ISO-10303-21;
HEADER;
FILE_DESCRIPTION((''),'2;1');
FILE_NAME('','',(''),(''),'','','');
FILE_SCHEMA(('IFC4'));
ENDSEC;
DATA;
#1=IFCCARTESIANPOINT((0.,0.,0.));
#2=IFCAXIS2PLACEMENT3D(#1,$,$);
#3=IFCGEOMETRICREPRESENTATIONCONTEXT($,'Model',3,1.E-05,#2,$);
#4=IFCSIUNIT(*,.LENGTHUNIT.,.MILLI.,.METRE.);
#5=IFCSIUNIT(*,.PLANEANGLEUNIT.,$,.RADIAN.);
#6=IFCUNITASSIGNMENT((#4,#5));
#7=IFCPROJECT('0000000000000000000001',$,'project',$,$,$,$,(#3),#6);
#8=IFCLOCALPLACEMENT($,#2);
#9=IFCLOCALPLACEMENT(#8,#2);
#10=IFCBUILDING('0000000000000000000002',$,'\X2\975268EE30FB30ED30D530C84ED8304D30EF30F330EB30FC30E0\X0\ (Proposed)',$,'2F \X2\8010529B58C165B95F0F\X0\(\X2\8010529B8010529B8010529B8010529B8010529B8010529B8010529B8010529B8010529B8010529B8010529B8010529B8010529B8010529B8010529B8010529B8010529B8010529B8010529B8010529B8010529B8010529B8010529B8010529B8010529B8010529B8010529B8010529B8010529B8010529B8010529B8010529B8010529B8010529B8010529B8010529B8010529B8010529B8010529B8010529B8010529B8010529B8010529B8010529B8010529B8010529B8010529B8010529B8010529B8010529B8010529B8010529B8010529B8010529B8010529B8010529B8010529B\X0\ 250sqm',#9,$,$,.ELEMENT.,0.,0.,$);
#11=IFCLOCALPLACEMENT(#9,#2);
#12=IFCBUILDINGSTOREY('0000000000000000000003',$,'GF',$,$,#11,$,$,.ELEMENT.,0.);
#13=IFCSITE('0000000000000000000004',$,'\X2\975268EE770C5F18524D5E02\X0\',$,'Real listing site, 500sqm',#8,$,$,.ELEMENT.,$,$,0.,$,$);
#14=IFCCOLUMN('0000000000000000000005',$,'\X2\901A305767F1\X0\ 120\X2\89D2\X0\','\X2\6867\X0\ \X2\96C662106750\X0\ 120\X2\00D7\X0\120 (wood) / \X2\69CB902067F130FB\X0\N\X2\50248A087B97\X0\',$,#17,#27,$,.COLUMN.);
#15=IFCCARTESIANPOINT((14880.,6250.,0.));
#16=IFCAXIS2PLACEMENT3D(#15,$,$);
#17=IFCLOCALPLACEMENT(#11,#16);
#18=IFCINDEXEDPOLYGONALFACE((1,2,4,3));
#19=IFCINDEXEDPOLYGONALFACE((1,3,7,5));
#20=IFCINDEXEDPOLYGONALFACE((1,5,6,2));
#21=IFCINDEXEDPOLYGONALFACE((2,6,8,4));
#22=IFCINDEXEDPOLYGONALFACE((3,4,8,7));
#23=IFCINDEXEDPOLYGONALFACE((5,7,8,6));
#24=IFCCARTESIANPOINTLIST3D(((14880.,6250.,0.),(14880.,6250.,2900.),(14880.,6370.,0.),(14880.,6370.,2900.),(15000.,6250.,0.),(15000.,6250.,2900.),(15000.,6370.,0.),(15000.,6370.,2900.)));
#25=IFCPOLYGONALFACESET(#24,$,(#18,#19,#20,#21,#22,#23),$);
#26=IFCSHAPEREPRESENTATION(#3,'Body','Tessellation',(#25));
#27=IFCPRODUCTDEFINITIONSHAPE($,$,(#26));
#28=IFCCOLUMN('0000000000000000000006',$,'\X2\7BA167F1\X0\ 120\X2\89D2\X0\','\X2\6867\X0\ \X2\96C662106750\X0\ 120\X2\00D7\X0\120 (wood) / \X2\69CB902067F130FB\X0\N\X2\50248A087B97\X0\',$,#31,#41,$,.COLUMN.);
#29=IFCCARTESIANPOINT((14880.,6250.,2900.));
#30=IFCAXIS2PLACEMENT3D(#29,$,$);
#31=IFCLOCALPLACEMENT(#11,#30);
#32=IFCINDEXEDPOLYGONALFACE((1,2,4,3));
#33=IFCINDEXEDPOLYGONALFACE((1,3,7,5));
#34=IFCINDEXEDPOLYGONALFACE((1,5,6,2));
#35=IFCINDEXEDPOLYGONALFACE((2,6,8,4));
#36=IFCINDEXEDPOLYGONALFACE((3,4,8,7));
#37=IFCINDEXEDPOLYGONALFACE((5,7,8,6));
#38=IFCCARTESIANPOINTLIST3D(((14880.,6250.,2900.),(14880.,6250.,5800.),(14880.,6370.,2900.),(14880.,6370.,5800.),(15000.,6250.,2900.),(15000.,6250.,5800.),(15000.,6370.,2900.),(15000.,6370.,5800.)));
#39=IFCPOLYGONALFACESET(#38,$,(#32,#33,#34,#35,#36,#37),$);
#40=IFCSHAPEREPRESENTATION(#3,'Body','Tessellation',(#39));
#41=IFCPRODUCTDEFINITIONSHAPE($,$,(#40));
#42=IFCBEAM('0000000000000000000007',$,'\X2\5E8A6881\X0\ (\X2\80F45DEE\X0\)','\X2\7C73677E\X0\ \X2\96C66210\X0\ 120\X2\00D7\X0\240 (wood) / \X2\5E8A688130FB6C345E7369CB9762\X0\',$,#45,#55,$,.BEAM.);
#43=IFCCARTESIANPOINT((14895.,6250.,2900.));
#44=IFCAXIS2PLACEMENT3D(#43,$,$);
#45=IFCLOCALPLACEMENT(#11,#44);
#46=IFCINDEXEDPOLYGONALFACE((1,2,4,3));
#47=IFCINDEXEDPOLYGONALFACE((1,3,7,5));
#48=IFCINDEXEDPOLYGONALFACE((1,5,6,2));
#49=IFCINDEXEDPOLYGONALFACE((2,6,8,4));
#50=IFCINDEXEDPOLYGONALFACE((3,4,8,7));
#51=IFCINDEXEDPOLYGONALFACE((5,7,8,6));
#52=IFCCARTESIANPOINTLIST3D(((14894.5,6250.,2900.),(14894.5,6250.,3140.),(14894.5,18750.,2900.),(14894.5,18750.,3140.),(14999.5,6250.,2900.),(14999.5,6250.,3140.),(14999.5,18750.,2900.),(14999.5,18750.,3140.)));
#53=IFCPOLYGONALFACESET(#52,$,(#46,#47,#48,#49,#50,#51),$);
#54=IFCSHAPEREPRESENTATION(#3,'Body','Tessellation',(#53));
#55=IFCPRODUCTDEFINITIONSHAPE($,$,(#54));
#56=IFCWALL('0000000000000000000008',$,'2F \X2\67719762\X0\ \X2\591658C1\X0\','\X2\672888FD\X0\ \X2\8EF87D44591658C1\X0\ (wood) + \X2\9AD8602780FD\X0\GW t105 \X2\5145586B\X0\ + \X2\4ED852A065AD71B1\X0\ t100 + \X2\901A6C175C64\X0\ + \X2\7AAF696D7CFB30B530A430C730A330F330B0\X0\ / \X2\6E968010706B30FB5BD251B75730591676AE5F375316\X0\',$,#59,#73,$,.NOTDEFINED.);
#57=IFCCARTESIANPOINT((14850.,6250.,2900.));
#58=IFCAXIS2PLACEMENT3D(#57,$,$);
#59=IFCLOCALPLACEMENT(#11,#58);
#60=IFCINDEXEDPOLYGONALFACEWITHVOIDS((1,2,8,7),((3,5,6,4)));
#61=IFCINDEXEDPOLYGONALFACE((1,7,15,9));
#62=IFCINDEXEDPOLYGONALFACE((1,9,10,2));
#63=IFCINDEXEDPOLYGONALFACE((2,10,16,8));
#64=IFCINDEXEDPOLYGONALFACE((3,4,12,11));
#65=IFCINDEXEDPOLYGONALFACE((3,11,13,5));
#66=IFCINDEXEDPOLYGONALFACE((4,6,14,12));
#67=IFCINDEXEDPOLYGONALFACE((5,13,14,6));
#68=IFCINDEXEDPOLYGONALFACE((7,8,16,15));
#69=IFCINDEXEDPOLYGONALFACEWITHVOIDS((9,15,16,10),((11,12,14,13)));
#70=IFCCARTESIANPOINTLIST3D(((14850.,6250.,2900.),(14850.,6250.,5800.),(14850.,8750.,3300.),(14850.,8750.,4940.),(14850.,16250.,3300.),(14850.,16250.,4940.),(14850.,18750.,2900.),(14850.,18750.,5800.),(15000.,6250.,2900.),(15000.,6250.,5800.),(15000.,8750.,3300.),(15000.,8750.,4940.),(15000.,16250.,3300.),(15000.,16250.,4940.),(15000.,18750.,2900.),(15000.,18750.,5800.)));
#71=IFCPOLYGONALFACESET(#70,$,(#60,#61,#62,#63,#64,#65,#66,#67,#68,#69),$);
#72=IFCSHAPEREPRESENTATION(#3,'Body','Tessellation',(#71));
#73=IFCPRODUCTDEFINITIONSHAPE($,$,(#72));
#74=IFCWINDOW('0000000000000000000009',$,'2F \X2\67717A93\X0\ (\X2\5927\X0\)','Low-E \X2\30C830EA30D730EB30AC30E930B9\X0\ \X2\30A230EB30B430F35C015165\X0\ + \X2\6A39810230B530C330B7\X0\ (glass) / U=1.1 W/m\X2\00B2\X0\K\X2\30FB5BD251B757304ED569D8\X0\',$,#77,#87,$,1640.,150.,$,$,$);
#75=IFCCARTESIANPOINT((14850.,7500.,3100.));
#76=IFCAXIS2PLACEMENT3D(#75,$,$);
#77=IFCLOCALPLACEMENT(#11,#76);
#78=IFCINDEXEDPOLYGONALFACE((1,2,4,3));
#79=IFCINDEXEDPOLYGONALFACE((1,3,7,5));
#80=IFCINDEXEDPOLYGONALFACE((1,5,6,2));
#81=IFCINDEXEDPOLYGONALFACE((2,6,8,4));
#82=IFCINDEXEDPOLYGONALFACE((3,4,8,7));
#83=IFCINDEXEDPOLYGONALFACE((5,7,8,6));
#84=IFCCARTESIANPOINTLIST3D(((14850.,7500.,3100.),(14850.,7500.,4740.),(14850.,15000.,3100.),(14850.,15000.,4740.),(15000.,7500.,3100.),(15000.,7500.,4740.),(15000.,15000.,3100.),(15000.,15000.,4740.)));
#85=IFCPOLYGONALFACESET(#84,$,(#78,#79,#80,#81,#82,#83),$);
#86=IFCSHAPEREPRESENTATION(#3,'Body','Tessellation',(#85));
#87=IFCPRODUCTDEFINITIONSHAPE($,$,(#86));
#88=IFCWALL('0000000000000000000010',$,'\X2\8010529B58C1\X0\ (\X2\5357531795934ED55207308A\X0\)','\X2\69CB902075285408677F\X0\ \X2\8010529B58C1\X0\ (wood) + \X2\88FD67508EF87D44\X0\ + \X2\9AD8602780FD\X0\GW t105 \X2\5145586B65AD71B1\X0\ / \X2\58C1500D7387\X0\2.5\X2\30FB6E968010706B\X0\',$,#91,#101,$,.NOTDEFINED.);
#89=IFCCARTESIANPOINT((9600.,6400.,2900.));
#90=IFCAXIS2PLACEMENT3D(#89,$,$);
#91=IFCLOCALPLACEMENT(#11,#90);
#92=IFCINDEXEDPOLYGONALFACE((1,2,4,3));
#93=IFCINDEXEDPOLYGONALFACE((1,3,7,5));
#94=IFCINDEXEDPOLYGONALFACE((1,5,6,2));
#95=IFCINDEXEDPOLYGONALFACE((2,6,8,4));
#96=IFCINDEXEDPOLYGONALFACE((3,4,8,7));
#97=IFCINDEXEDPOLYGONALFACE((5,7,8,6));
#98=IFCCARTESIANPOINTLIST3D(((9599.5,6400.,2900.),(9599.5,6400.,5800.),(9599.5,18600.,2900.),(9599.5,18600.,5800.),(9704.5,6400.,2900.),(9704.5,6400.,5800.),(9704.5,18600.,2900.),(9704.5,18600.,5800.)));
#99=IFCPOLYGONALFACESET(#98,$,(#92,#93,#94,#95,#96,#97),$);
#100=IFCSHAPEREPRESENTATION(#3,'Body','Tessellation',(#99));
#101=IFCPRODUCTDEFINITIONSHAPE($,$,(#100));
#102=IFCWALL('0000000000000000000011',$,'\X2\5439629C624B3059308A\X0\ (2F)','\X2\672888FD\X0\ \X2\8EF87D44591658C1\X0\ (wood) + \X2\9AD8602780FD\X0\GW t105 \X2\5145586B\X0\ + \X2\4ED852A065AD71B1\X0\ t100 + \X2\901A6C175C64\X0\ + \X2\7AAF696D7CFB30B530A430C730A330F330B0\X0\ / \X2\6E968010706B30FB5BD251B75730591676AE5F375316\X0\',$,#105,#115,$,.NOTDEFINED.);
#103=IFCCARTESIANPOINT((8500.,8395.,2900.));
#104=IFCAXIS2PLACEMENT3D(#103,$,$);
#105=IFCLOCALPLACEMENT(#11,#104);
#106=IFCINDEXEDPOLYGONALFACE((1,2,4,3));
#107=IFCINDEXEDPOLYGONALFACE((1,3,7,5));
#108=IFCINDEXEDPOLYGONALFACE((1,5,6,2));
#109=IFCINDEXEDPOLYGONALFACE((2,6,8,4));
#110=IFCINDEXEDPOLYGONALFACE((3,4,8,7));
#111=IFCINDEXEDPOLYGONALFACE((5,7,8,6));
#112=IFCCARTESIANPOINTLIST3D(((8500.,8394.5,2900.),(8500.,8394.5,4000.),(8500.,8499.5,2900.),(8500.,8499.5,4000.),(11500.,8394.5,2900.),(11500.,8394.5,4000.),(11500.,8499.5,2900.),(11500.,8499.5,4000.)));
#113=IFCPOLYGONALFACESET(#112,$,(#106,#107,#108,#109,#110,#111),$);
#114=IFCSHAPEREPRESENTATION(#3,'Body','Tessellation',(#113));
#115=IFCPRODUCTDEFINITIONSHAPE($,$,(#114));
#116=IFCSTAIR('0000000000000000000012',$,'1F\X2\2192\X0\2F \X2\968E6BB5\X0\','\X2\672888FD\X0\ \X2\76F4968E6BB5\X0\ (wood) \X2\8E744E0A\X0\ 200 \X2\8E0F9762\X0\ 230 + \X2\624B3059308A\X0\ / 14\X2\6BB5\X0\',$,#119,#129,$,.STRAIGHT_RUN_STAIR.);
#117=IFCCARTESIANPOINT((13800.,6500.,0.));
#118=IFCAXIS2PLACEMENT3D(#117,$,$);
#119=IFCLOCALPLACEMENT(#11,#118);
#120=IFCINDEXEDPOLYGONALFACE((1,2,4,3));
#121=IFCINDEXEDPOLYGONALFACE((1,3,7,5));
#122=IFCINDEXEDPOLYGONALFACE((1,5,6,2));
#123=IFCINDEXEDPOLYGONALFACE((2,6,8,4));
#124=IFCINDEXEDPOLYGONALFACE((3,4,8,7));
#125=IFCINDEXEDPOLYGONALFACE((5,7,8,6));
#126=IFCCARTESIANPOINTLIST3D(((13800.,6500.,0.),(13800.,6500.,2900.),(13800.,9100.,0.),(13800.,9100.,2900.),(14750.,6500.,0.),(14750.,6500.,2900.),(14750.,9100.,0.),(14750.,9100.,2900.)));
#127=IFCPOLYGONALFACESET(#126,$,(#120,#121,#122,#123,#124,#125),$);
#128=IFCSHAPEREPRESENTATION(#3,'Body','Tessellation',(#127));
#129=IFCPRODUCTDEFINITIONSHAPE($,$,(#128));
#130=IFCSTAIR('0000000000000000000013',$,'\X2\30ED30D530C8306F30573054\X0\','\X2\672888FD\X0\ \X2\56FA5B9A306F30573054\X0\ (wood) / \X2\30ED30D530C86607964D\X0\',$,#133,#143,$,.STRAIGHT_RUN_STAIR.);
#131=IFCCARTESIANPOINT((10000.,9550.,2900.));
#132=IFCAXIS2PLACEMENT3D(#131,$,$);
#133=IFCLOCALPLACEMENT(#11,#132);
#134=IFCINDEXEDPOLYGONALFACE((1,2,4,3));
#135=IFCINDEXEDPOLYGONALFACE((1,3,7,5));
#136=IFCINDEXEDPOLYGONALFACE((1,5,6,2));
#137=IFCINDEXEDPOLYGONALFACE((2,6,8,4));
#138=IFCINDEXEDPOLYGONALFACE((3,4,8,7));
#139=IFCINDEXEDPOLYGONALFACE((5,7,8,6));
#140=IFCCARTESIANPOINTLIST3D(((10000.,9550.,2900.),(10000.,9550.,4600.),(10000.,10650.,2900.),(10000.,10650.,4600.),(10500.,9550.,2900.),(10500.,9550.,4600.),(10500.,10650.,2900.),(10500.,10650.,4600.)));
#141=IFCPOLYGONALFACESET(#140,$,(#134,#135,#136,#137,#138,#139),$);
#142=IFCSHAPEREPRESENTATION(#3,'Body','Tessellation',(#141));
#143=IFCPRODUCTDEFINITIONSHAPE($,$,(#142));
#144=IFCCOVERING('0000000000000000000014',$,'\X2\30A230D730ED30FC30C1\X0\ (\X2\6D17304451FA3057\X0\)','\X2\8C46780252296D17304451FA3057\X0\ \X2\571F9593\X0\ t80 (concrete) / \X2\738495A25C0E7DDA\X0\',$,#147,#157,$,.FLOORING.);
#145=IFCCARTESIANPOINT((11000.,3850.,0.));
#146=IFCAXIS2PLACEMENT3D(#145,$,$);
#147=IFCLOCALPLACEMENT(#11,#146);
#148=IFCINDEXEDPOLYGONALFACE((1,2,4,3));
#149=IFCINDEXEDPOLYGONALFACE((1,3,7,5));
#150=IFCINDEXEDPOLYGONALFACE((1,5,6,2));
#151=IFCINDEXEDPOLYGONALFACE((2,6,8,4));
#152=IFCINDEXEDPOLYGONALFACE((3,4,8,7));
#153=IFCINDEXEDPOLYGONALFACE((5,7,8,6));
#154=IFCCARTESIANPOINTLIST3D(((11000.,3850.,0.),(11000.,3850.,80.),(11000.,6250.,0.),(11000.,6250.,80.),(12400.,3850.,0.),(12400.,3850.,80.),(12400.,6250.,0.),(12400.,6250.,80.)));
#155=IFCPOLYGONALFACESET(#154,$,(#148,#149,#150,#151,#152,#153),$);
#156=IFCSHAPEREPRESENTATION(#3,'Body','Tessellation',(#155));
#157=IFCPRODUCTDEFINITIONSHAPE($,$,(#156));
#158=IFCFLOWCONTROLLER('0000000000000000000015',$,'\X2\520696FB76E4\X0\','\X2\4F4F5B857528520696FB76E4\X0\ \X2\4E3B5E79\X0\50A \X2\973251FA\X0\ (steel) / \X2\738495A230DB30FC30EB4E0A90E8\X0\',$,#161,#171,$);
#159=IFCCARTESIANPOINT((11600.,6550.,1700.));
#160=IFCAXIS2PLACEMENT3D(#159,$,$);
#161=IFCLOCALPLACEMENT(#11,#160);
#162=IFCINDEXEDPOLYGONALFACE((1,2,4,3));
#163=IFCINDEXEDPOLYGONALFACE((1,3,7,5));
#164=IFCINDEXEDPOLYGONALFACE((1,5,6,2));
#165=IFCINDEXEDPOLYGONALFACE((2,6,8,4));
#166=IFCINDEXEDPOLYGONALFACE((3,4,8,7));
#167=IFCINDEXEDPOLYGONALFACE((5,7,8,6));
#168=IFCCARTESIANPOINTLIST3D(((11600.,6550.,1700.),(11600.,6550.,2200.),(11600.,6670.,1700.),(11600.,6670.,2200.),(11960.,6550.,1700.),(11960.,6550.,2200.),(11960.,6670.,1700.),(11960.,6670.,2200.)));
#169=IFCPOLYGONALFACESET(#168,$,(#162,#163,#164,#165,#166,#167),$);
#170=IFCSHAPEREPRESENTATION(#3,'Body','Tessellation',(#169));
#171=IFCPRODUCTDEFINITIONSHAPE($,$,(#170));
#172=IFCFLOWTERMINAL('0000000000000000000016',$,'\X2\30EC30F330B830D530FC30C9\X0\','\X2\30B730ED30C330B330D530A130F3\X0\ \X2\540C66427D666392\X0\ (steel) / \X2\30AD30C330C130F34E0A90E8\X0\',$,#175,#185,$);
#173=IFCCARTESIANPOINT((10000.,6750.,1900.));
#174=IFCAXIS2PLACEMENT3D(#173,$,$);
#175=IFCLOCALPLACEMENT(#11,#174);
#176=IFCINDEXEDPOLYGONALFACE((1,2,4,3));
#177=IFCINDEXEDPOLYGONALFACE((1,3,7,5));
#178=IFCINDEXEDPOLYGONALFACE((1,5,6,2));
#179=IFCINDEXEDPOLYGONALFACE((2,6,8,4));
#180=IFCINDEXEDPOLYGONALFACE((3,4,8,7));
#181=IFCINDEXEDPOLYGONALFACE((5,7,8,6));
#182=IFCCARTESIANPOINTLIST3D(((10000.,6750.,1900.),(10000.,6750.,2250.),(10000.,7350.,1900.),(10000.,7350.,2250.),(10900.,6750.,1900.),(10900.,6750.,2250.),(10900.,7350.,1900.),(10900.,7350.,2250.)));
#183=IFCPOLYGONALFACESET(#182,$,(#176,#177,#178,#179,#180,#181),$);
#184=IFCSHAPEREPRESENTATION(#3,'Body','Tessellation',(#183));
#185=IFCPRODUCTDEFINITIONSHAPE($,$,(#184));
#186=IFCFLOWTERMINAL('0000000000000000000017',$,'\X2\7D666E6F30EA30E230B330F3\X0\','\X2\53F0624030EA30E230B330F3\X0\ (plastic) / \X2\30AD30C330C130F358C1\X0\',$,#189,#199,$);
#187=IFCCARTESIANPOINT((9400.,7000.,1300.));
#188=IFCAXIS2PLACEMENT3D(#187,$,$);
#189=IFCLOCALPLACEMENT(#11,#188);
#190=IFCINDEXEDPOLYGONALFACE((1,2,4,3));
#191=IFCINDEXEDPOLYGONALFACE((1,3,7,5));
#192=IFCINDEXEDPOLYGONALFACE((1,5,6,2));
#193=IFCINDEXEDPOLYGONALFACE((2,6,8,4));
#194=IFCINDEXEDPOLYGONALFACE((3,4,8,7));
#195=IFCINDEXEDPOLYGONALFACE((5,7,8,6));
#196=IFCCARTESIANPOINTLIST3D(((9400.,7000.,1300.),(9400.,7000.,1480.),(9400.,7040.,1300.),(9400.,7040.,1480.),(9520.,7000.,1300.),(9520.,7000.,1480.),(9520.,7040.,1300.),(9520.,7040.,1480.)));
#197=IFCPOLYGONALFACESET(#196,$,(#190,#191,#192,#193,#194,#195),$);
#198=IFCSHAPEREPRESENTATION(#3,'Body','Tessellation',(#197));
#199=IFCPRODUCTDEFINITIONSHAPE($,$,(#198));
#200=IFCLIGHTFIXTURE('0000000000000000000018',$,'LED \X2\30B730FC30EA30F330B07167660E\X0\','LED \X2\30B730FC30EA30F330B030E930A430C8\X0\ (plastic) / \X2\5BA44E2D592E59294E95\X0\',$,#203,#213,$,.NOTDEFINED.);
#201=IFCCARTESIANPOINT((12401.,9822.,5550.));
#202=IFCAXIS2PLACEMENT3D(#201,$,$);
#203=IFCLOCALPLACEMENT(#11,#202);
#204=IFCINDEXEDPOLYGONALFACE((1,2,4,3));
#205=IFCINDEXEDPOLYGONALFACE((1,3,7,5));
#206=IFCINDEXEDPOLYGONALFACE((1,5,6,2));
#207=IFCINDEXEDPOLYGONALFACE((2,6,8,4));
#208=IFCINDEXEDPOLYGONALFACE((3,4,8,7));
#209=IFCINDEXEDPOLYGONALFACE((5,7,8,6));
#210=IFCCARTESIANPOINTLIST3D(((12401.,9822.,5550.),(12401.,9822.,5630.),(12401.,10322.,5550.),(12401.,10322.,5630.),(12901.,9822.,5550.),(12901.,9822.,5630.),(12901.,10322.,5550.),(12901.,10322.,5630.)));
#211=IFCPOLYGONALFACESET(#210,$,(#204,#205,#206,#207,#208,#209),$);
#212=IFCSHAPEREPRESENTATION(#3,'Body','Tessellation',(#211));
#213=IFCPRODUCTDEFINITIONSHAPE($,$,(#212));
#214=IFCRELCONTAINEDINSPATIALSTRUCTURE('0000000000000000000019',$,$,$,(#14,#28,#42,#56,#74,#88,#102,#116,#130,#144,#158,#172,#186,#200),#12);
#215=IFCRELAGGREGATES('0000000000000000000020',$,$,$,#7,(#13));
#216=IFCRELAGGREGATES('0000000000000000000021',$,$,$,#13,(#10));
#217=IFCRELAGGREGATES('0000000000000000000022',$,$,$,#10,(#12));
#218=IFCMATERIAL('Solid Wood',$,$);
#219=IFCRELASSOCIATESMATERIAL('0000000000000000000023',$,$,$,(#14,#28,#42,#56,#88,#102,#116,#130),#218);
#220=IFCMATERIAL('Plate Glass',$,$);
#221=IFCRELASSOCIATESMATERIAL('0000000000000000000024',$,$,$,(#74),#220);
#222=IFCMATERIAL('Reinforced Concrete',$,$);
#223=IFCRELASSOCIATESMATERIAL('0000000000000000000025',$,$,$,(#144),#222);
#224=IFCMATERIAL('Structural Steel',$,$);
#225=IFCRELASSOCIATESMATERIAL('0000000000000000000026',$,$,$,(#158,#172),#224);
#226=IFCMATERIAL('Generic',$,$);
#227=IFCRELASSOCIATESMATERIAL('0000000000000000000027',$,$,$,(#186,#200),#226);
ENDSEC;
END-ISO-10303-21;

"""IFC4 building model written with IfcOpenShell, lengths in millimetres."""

from ifc_helpers import new_model, si_unit, frame, frame_2d, origin, place, context, project, spatial, rectangle, extrude, material, element, fill, save


model = new_model("IFC4")

# Units and contexts
model_context = context("Model", 3, precision=1e-05, world=origin())
ifc_project = project(units=[si_unit("LENGTHUNIT", "METRE", prefix="MILLI"), si_unit("PLANEANGLEUNIT", "RADIAN")], contexts=[model_context])

# Site, building, storey
site_placement = place(None, origin())
site = spatial("IfcSite", under=ifc_project, at=site_placement, Name="青森県弘前市", ObjectType="Real listing site, 500sqm", CompositionType="ELEMENT", RefElevation=0.0)
building_placement = place(site_placement, origin())
building = spatial("IfcBuilding", under=site, at=building_placement, Name="青森・ロフト付きワンルーム (Proposed)", ObjectType="2F 耐力壁方式(耐力耐力耐力耐力耐力耐力耐力耐力耐力耐力耐力耐力耐力耐力耐力耐力耐力耐力耐力耐力耐力耐力耐力耐力耐力耐力耐力耐力耐力耐力耐力耐力耐力耐力耐力耐力耐力耐力耐力耐力耐力耐力耐力耐力耐力耐力耐力耐力耐力耐力耐力耐力耐力耐力耐力耐力耐力 250sqm", CompositionType="ELEMENT", ElevationOfRefHeight=0.0, ElevationOfTerrain=0.0)
storey_placement = place(building_placement, origin())
storey = spatial("IfcBuildingStorey", under=building, at=storey_placement, Name="GF", CompositionType="ELEMENT", Elevation=0.0)

# Columns
ifc_material_1 = material(Name="Solid Wood")
column_1_placement = place(storey_placement, frame((14880.0, 6250.0, 0.0)))
element("IfcColumn", 1, at=column_1_placement, inside=storey, material=ifc_material_1, Name="通し柱 120角", Description="桧 集成材 120×120 (wood) / 構造柱・N値計算", PredefinedType="COLUMN", context=model_context, shape_type="SweptSolid", body=[
    extrude(rectangle(XDim=120.0, YDim=120.0, at=frame_2d((60.0, 60.0))), frame((14880.0, 6250.0, 0.0)), (0.0, 0.0, 1.0), 2900.0),
])
column_2_placement = place(storey_placement, frame((14880.0, 6250.0, 2900.0)))
element("IfcColumn", 2, at=column_2_placement, inside=storey, material=ifc_material_1, Name="管柱 120角", Description="桧 集成材 120×120 (wood) / 構造柱・N値計算", PredefinedType="COLUMN", context=model_context, shape_type="SweptSolid", body=[
    extrude(rectangle(XDim=120.0, YDim=120.0, at=frame_2d((60.0, 60.0))), frame((14880.0, 6250.0, 2900.0)), (0.0, 0.0, 1.0), 2900.0),
])

# Beam
beam_1_placement = place(storey_placement, frame((14895.0, 6250.0, 2900.0)))
element("IfcBeam", 3, at=beam_1_placement, inside=storey, material=ifc_material_1, Name="床梁 (胴差)", Description="米松 集成 120×240 (wood) / 床梁・水平構面", PredefinedType="BEAM", context=model_context, shape_type="SweptSolid", body=[
    extrude(rectangle(XDim=105.0, YDim=12500.0, at=frame_2d((52.0, 6250.0))), frame((14895.0, 6250.0, 2900.0)), (0.0, 0.0, 1.0), 240.0),
])

# Shared definitions
ifc_material_2 = material(Name="Plate Glass")

# Wall, opening, window
wall_1_placement = place(storey_placement, frame((14850.0, 6250.0, 2900.0)))
wall_1 = element("IfcWall", 4, at=wall_1_placement, inside=storey, material=ifc_material_1, Name="2F 東面 外壁", Description="木製 軸組外壁 (wood) + 高性能GW t105 充填 + 付加断熱 t100 + 通気層 + 窯業系サイディング / 準耐火・寒冷地外皮強化", PredefinedType="NOTDEFINED", context=model_context, shape_type="SweptSolid", body=[
    extrude(rectangle(XDim=150.0, YDim=12500.0, at=frame_2d((75.0, 6250.0))), frame((14850.0, 6250.0, 2900.0)), (0.0, 0.0, 1.0), 2900.0),
])
opening_1_placement = place(storey_placement, frame((14850.0, 7500.0, 3100.0)))
opening_1 = element("IfcOpeningElement", 5, at=opening_1_placement, cuts=wall_1, PredefinedType="NOTDEFINED", context=model_context, shape_type="SweptSolid", body=[
    extrude(rectangle(XDim=150.0, YDim=7500.0, at=frame_2d((75.0, 3750.0))), frame((14850.0, 7500.0, 3100.0)), (0.0, 0.0, 1.0), 1640.0),
])
window_1_placement = place(storey_placement, frame((14850.0, 7500.0, 3100.0)))
window_1 = element("IfcWindow", 6, at=window_1_placement, inside=storey, material=ifc_material_2, Name="2F 東窓 (大)", Description="Low-E トリプルガラス アルゴン封入 + 樹脂サッシ (glass) / U=1.1 W/m²K・寒冷地仕様", OverallHeight=1640.0, OverallWidth=150.0, context=model_context, shape_type="SweptSolid", body=[
    extrude(rectangle(XDim=150.0, YDim=7500.0, at=frame_2d((75.0, 3750.0))), frame((14850.0, 7500.0, 3100.0)), (0.0, 0.0, 1.0), 1640.0),
])
fill(opening_1, window_1)

# Walls
wall_2_placement = place(storey_placement, frame((9600.0, 6400.0, 2900.0)))
element("IfcWall", 7, at=wall_2_placement, inside=storey, material=ifc_material_1, Name="耐力壁 (南北間仕切り)", Description="構造用合板 耐力壁 (wood) + 製材軸組 + 高性能GW t105 充填断熱 / 壁倍率2.5・準耐火", PredefinedType="NOTDEFINED", context=model_context, shape_type="SweptSolid", body=[
    extrude(rectangle(XDim=105.0, YDim=12200.0, at=frame_2d((52.0, 6100.0))), frame((9600.0, 6400.0, 2900.0)), (0.0, 0.0, 1.0), 2900.0),
])
wall_3_placement = place(storey_placement, frame((8500.0, 8395.0, 2900.0)))
element("IfcWall", 8, at=wall_3_placement, inside=storey, material=ifc_material_1, Name="吹抜手すり (2F)", Description="木製 軸組外壁 (wood) + 高性能GW t105 充填 + 付加断熱 t100 + 通気層 + 窯業系サイディング / 準耐火・寒冷地外皮強化", PredefinedType="NOTDEFINED", context=model_context, shape_type="SweptSolid", body=[
    extrude(rectangle(XDim=3000.0, YDim=105.0, at=frame_2d((1500.0, 52.0))), frame((8500.0, 8395.0, 2900.0)), (0.0, 0.0, 1.0), 1100.0),
])

# Stairs
stair_1_placement = place(storey_placement, frame((13800.0, 6500.0, 0.0)))
element("IfcStair", 9, at=stair_1_placement, inside=storey, material=ifc_material_1, Name="1F→2F 階段", Description="木製 直階段 (wood) 蹴上 200 踏面 230 + 手すり / 14段", PredefinedType="STRAIGHT_RUN_STAIR", context=model_context, shape_type="SweptSolid", body=[
    extrude(rectangle(XDim=950.0, YDim=2600.0, at=frame_2d((475.0, 1300.0))), frame((13800.0, 6500.0, 0.0)), (0.0, 0.0, 1.0), 2900.0),
])
stair_2_placement = place(storey_placement, frame((10000.0, 9550.0, 2900.0)))
element("IfcStair", 10, at=stair_2_placement, inside=storey, material=ifc_material_1, Name="ロフトはしご", Description="木製 固定はしご (wood) / ロフト昇降", PredefinedType="STRAIGHT_RUN_STAIR", context=model_context, shape_type="SweptSolid", body=[
    extrude(rectangle(XDim=500.0, YDim=1100.0, at=frame_2d((250.0, 550.0))), frame((10000.0, 9550.0, 2900.0)), (0.0, 0.0, 1.0), 1700.0),
])

# Covering
ifc_material_3 = material(Name="Reinforced Concrete")
covering_placement = place(storey_placement, frame((11000.0, 3850.0, 0.0)))
element("IfcCovering", 11, at=covering_placement, inside=storey, material=ifc_material_3, Name="アプローチ (洗い出し)", Description="豆砂利洗い出し 土間 t80 (concrete) / 玄関導線", PredefinedType="FLOORING", context=model_context, shape_type="SweptSolid", body=[
    extrude(rectangle(XDim=1400.0, YDim=2400.0, at=frame_2d((700.0, 1200.0))), frame((11000.0, 3850.0, 0.0)), (0.0, 0.0, 1.0), 80.0),
])

# Flow controller
ifc_material_4 = material(Name="Structural Steel")
flow_controller_placement = place(storey_placement, frame((11600.0, 6550.0, 1700.0)))
element("IfcFlowController", 12, at=flow_controller_placement, inside=storey, material=ifc_material_4, Name="分電盤", Description="住宅用分電盤 主幹50A 露出 (steel) / 玄関ホール上部", context=model_context, shape_type="SweptSolid", body=[
    extrude(rectangle(XDim=360.0, YDim=120.0, at=frame_2d((180.0, 60.0))), frame((11600.0, 6550.0, 1700.0)), (0.0, 0.0, 1.0), 500.0),
])

# Flow terminals
flow_terminal_1_placement = place(storey_placement, frame((10000.0, 6750.0, 1900.0)))
element("IfcFlowTerminal", 13, at=flow_terminal_1_placement, inside=storey, material=ifc_material_4, Name="レンジフード", Description="シロッコファン 同時給排 (steel) / キッチン上部", context=model_context, shape_type="SweptSolid", body=[
    extrude(rectangle(XDim=900.0, YDim=600.0, at=frame_2d((450.0, 300.0))), frame((10000.0, 6750.0, 1900.0)), (0.0, 0.0, 1.0), 350.0),
])
ifc_material_5 = material(Name="Generic")
flow_terminal_2_placement = place(storey_placement, frame((9400.0, 7000.0, 1300.0)))
element("IfcFlowTerminal", 14, at=flow_terminal_2_placement, inside=storey, material=ifc_material_5, Name="給湯リモコン", Description="台所リモコン (plastic) / キッチン壁", context=model_context, shape_type="SweptSolid", body=[
    extrude(rectangle(XDim=120.0, YDim=40.0, at=frame_2d((60.0, 20.0))), frame((9400.0, 7000.0, 1300.0)), (0.0, 0.0, 1.0), 180.0),
])

# Light fixture
light_fixture_placement = place(storey_placement, frame((12401.0, 9822.0, 5550.0)))
element("IfcLightFixture", 15, at=light_fixture_placement, inside=storey, material=ifc_material_5, Name="LED シーリング照明", Description="LED シーリングライト (plastic) / 室中央天井", PredefinedType="NOTDEFINED", context=model_context, shape_type="SweptSolid", body=[
    extrude(rectangle(XDim=500.0, YDim=500.0, at=frame_2d((250.0, 250.0))), frame((12401.0, 9822.0, 5550.0)), (0.0, 0.0, 1.0), 80.0),
])

save(model, "model.ifc")
